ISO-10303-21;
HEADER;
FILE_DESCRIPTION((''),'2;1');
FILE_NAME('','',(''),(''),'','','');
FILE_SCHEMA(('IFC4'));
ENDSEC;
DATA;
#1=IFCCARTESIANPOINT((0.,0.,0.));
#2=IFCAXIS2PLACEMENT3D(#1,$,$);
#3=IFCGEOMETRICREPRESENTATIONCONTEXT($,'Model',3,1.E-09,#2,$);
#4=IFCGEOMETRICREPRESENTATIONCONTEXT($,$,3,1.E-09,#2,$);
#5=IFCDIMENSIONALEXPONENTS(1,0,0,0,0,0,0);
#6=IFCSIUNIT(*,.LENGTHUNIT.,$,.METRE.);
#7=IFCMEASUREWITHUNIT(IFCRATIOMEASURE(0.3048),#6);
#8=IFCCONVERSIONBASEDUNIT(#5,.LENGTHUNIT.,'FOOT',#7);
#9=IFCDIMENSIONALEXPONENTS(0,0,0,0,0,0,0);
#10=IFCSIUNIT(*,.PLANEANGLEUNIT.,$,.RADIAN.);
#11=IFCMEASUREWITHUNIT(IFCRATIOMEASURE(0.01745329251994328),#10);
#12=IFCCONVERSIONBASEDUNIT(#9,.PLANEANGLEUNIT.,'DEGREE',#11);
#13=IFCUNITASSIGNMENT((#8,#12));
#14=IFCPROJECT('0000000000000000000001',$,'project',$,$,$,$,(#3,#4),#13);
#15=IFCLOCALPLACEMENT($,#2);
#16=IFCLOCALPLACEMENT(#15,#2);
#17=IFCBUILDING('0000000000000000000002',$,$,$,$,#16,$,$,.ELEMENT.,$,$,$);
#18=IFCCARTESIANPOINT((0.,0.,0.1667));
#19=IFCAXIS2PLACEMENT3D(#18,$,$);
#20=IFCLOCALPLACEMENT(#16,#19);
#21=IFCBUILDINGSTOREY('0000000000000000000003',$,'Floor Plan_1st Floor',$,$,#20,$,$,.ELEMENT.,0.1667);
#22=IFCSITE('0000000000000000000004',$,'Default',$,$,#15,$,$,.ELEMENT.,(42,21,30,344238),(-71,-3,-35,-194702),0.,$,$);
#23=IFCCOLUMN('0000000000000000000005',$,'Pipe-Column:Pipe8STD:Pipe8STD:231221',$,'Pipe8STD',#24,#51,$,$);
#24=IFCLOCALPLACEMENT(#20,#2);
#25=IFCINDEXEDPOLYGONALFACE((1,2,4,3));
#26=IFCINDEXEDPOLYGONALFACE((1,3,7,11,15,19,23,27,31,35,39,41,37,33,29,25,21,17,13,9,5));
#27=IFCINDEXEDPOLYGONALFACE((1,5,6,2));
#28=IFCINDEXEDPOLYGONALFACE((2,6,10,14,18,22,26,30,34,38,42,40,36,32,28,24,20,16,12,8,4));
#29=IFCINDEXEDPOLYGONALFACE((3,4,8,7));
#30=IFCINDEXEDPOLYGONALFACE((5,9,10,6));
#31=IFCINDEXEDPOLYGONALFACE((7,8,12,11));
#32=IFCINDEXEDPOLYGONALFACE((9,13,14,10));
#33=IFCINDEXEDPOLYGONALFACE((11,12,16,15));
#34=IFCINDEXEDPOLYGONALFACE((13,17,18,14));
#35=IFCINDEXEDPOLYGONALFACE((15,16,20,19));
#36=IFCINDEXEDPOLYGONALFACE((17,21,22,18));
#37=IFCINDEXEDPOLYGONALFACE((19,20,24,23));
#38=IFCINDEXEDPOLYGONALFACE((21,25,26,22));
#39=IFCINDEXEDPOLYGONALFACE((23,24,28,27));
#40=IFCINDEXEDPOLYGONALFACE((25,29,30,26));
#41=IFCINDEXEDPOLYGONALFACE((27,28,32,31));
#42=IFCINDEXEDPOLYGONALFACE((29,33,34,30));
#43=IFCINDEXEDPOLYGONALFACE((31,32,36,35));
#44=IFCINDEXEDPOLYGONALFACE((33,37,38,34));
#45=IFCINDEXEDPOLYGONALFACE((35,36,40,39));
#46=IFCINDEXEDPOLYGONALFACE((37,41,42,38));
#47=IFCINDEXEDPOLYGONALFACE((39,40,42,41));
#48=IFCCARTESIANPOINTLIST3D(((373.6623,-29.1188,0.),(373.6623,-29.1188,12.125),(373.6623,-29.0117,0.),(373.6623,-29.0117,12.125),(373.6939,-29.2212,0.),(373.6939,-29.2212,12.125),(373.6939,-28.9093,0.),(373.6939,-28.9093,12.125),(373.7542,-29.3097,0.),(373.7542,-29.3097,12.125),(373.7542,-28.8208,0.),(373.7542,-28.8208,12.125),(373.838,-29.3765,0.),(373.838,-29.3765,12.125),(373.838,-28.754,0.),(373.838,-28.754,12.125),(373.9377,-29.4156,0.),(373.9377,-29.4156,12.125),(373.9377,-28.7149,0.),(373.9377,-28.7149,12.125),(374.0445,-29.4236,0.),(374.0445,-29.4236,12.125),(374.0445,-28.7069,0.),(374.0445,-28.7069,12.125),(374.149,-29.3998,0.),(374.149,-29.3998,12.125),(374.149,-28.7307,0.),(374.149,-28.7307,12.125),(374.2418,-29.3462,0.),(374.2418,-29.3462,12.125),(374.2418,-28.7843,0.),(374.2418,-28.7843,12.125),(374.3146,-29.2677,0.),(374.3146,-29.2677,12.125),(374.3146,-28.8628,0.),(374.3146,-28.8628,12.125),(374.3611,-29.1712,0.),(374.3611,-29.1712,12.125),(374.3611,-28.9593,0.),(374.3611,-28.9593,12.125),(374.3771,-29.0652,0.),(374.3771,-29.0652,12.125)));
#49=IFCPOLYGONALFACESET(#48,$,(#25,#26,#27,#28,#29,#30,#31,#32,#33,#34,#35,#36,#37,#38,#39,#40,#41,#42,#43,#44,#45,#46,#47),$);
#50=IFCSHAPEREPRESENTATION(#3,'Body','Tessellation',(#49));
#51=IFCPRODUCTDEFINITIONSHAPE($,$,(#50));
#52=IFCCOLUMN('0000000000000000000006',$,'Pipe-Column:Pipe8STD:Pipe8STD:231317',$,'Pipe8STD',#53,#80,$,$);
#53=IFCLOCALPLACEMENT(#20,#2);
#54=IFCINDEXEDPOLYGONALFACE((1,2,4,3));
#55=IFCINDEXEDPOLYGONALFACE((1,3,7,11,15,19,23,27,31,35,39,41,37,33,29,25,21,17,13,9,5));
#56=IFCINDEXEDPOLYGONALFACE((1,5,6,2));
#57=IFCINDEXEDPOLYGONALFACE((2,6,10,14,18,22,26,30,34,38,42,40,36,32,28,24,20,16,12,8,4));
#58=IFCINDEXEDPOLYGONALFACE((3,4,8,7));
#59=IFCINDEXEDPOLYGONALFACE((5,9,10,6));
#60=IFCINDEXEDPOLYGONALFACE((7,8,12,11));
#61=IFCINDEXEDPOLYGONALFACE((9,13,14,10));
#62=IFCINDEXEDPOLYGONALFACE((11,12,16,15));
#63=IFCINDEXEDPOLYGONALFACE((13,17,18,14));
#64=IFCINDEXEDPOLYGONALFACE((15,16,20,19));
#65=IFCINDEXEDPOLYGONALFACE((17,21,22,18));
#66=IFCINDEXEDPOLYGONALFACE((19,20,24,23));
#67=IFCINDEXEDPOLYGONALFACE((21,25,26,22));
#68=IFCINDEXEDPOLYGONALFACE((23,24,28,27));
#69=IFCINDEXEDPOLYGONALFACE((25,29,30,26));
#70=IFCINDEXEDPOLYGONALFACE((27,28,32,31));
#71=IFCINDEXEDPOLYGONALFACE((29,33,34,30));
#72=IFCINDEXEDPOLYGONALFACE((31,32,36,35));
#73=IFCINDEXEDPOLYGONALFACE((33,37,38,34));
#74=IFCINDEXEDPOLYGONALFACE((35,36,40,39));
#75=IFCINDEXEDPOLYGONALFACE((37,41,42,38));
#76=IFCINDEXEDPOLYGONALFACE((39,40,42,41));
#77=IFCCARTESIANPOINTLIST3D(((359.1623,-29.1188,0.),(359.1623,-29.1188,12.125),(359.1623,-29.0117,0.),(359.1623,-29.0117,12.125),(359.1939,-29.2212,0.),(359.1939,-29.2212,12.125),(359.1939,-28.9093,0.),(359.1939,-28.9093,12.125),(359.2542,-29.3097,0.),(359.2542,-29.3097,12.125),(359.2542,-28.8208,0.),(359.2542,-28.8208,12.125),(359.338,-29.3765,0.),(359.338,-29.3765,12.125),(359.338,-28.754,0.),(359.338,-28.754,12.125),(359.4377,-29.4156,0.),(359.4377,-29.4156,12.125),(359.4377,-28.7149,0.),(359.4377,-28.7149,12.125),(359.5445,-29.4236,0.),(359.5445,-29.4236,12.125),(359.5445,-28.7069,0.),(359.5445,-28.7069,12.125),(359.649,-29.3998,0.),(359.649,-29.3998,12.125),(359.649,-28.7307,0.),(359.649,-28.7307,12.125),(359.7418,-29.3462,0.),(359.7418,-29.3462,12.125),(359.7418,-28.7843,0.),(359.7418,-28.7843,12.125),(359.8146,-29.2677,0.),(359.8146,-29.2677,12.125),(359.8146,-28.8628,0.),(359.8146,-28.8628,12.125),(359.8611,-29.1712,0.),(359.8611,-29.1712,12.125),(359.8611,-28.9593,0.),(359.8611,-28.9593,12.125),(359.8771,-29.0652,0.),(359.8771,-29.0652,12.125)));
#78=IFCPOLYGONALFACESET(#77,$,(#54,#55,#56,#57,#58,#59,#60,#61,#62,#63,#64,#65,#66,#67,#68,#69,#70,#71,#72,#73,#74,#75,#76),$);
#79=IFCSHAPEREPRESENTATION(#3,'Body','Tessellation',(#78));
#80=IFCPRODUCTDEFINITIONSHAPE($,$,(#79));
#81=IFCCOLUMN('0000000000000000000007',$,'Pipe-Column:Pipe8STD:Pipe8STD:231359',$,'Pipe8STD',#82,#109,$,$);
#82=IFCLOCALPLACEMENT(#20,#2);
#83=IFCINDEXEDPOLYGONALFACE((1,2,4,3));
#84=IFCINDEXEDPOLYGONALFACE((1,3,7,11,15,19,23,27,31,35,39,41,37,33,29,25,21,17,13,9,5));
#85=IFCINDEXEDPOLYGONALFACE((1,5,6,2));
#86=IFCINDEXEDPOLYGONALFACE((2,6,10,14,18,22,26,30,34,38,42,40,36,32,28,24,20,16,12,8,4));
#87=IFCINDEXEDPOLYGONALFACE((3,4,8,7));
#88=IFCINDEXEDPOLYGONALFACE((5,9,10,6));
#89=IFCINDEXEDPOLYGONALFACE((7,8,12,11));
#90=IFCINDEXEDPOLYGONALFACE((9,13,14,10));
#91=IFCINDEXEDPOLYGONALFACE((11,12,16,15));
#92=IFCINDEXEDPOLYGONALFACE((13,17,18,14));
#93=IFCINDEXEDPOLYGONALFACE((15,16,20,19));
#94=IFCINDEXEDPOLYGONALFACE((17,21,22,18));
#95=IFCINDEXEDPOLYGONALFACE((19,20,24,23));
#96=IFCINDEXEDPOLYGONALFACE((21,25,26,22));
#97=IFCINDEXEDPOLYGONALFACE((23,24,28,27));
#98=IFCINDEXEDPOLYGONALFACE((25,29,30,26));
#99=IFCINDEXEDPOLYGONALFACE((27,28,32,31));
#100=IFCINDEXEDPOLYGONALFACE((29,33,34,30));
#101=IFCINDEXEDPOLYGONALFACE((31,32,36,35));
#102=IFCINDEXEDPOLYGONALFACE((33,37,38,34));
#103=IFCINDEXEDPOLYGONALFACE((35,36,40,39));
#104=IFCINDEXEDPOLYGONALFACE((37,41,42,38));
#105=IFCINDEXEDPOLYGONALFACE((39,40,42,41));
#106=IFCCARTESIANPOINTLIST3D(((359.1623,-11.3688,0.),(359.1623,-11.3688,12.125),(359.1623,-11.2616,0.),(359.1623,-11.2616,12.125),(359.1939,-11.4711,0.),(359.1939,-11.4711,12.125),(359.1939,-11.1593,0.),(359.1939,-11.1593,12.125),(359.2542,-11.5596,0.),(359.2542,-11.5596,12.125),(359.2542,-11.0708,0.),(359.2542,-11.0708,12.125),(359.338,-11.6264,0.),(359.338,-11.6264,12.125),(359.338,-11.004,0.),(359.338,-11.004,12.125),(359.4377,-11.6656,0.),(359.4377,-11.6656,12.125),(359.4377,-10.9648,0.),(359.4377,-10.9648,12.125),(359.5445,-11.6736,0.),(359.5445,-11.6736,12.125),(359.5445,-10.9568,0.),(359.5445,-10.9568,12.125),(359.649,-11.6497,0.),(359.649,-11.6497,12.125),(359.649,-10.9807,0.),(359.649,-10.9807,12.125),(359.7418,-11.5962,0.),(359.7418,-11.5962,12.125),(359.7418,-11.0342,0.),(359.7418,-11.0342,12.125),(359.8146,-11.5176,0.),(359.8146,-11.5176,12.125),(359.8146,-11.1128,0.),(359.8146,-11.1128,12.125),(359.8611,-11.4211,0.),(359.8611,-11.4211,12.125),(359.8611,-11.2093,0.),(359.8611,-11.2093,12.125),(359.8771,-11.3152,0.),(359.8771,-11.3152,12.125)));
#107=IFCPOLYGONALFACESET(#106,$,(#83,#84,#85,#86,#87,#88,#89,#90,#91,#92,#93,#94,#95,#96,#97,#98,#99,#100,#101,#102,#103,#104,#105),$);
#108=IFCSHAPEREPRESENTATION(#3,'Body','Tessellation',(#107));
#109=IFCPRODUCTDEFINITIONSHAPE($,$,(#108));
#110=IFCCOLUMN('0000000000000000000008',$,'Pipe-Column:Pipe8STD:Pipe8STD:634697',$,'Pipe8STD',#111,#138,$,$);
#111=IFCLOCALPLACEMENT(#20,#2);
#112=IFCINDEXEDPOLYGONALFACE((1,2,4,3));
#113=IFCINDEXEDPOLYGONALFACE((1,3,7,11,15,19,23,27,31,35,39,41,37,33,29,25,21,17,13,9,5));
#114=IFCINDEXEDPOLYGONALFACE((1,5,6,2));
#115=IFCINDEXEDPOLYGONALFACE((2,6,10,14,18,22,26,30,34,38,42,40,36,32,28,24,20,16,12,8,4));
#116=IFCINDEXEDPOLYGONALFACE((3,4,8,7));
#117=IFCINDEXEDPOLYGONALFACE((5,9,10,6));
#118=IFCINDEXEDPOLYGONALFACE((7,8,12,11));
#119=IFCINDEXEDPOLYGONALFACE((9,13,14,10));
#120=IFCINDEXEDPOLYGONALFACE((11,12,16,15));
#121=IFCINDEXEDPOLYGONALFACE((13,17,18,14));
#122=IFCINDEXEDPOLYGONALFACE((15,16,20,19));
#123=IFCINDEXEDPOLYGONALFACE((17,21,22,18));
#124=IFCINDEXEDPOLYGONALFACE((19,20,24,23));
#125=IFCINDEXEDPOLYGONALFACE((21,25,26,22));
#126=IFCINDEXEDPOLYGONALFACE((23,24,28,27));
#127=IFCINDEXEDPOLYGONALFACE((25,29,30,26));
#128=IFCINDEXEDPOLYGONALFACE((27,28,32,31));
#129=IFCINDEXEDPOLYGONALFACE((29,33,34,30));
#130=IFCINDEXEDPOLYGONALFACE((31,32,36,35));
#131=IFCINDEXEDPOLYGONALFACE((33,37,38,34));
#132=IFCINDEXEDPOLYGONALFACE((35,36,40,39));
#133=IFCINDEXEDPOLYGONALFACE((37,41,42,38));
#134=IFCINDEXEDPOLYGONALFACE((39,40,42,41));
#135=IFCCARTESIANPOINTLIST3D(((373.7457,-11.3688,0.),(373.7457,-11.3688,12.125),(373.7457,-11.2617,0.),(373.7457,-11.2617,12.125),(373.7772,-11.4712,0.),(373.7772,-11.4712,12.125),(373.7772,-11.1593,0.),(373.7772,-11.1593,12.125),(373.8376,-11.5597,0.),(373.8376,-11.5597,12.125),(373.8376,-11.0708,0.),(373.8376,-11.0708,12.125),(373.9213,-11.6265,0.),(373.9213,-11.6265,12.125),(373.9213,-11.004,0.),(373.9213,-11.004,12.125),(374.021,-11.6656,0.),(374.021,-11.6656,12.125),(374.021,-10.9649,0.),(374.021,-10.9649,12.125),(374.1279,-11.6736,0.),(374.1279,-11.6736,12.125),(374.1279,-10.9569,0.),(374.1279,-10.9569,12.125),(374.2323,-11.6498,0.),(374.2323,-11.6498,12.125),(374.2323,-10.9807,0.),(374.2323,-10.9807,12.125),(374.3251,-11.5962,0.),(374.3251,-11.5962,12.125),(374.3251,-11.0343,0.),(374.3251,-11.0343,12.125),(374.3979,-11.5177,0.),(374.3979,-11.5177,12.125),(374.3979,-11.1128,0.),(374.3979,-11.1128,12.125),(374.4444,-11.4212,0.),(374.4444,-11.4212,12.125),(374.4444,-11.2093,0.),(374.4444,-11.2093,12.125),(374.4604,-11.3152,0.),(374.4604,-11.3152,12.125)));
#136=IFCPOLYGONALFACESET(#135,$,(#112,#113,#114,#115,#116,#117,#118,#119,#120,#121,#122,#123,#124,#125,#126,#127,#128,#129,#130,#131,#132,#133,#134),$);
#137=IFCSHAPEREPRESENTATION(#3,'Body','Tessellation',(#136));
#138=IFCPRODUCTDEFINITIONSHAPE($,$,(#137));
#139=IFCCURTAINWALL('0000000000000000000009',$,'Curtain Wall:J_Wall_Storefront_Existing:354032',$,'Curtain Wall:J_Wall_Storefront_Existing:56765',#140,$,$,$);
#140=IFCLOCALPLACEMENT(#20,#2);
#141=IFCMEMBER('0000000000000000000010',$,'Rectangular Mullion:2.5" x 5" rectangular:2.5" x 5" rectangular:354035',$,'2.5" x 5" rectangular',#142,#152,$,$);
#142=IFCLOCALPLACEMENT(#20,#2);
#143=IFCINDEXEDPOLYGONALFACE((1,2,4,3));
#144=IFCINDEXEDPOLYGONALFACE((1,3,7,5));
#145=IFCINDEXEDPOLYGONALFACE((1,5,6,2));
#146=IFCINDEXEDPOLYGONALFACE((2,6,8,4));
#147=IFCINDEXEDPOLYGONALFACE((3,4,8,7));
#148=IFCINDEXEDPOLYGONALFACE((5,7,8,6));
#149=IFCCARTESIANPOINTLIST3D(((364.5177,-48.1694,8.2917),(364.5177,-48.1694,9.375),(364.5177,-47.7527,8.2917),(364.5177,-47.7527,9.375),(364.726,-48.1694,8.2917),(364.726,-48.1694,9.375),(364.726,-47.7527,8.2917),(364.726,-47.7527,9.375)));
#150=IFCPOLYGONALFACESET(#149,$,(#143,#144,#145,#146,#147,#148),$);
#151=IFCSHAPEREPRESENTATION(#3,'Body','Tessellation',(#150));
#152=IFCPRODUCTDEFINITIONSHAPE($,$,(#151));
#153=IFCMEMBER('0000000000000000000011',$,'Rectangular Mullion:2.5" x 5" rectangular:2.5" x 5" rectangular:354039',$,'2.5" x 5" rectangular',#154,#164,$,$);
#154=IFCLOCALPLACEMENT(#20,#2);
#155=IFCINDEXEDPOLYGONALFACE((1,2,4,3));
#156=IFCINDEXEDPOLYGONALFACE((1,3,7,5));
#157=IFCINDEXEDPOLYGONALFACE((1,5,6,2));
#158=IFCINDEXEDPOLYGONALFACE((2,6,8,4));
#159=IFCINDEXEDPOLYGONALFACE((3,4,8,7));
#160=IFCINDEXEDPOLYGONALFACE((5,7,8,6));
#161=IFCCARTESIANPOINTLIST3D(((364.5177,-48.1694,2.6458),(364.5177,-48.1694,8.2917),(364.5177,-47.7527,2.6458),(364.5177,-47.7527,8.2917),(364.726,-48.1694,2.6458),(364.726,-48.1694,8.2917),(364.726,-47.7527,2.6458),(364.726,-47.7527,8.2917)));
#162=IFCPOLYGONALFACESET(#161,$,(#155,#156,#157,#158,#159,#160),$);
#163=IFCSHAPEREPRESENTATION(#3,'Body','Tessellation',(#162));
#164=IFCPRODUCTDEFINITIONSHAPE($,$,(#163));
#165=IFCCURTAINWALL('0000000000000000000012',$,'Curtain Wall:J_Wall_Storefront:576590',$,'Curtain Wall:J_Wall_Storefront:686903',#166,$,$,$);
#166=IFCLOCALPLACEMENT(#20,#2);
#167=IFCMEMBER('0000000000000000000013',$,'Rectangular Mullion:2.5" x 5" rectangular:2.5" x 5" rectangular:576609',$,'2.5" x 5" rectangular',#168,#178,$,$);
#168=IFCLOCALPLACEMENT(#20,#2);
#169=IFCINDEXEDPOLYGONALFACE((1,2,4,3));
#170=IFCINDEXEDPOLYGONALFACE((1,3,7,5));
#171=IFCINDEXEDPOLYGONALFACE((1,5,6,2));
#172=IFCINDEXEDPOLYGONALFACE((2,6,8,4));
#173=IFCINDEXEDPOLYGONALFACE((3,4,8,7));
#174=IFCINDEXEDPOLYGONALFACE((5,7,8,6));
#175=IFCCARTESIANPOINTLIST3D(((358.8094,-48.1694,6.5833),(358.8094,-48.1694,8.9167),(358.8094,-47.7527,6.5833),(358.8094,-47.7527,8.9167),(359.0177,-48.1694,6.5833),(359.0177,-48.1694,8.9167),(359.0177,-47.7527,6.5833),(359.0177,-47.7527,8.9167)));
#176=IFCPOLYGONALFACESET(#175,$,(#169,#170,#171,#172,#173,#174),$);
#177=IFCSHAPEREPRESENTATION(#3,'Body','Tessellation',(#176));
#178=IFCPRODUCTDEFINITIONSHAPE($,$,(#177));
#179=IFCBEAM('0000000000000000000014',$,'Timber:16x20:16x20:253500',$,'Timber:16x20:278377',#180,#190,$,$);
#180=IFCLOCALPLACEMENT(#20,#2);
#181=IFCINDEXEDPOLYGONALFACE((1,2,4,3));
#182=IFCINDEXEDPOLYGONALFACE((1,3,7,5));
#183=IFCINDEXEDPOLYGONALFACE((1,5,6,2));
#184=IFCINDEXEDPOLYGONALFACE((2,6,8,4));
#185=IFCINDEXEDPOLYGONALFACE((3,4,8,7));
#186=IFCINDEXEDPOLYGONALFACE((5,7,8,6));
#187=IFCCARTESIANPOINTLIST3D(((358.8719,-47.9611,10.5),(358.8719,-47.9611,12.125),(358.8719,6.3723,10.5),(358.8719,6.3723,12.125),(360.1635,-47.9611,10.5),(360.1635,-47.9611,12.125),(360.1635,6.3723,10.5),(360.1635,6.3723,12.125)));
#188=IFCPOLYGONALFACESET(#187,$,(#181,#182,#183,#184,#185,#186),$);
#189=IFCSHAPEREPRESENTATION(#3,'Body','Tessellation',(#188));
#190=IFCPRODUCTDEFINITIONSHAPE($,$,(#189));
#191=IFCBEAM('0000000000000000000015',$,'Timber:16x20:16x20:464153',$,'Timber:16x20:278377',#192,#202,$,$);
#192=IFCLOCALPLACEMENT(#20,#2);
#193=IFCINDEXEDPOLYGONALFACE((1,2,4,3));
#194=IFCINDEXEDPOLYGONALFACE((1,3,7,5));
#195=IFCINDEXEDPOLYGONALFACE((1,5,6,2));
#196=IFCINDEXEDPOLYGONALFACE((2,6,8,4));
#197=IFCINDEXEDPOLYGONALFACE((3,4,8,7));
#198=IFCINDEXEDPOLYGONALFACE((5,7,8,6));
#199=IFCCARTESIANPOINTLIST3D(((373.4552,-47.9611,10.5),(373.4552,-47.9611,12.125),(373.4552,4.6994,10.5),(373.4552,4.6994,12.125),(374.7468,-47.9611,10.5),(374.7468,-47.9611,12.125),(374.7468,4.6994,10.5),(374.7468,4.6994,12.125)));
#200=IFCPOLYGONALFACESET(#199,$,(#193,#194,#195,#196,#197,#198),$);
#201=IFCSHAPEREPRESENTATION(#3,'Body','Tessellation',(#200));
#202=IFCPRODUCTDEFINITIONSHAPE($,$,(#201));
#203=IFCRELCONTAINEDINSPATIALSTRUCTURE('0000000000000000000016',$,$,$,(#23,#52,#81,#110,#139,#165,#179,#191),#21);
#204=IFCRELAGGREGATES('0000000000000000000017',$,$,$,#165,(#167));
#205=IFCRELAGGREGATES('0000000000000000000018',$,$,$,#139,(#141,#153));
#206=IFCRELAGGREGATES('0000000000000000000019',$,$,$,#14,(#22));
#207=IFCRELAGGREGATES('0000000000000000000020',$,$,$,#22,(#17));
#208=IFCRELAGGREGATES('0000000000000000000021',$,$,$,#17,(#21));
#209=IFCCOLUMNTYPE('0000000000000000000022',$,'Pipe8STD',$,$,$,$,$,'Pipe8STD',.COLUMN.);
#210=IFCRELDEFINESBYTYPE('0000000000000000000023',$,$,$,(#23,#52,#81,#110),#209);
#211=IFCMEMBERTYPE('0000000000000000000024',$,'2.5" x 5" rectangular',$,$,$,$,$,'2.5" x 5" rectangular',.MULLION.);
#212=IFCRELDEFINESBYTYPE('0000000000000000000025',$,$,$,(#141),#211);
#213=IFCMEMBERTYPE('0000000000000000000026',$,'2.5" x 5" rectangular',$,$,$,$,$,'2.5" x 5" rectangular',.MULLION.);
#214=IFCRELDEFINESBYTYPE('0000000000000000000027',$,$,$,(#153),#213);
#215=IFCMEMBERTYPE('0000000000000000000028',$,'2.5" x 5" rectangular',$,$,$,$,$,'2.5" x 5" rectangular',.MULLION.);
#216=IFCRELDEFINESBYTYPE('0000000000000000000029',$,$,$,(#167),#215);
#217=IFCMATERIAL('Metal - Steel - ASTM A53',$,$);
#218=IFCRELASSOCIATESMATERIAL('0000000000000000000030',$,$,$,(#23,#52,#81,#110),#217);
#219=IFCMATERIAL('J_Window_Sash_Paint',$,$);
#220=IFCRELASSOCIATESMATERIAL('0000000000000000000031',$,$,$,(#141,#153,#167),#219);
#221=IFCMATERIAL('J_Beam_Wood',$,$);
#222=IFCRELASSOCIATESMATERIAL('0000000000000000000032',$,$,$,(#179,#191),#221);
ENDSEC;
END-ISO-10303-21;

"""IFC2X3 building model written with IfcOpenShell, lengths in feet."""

from ifc_helpers import new_model, entity, si_unit, converted_unit, frame, frame_2d, origin, origin_2d_with_axis, place, context, project, spatial, rectangle, circle, extrude, source, transform, mapped, material, type_object, type_shapes, element, aggregate, save


model = new_model("IFC2X3")

# Units and contexts
model_context = context("Model", 3, precision=1e-09, world=origin())
context_of_model = context(None, 3, precision=1e-09, world=origin())
ifc_project = project(units=[converted_unit("LENGTHUNIT", "FOOT", entity("IfcRatioMeasure", 0.3048), si_unit("LENGTHUNIT", "METRE"), dimensions=[1, 0, 0, 0, 0, 0, 0]), converted_unit("PLANEANGLEUNIT", "DEGREE", entity("IfcRatioMeasure", 0.01745329251994328), si_unit("PLANEANGLEUNIT", "RADIAN"), dimensions=[0, 0, 0, 0, 0, 0, 0])], contexts=[model_context, context_of_model])

# Site, building, storey
site_placement = place(None, origin())
site = spatial("IfcSite", under=ifc_project, at=site_placement, Name="Default", CompositionType="ELEMENT", RefLatitude=(42, 21, 30, 344238), RefLongitude=(-71, -3, -35, -194702), RefElevation=0.0)
building_placement = place(site_placement, origin())
building = spatial("IfcBuilding", under=site, at=building_placement, CompositionType="ELEMENT")
storey_placement = place(building_placement, frame((0.0, 0.0, 0.1667)))
storey = spatial("IfcBuildingStorey", under=building, at=storey_placement, Name="Floor Plan_1st Floor", CompositionType="ELEMENT", Elevation=0.1667)

# Columns
ifc_material_1 = material(Name="Metal - Steel - ASTM A53")
column_type = type_object("IfcColumnType", Name="Pipe8STD", ElementType="Pipe8STD", PredefinedType="COLUMN")
shared_shape_1 = source(origin(), model_context, "Body", "SweptSolid", [
    extrude(circle(Radius=0.3594, at=origin_2d_with_axis()), origin(), (0.0, 0.0, 1.0), 12.125),
])
type_shapes(column_type, [shared_shape_1])
for number, where, name in (
    (1, (374.0177, -29.0652, 0.0), "Pipe-Column:Pipe8STD:Pipe8STD:231221"),
    (2, (359.5177, -29.0652, 0.0), "Pipe-Column:Pipe8STD:Pipe8STD:231317"),
    (3, (359.5177, -11.3152, 0.0), "Pipe-Column:Pipe8STD:Pipe8STD:231359"),
    (4, (374.101, -11.3152, 0.0), "Pipe-Column:Pipe8STD:Pipe8STD:634697"),
):
    element("IfcColumn", number, at=place(storey_placement, frame(where)), inside=storey, type_object=column_type, material=ifc_material_1, Name=name, ObjectType="Pipe8STD", context=model_context, shape_type="MappedRepresentation", body=[
        mapped(shared_shape_1, transform((0.0, 0.0, 0.0), scale=1.0)),
    ])

# Curtain wall, members
curtain_wall_1_placement = place(storey_placement, origin())
curtain_wall_1 = element("IfcCurtainWall", 5, at=curtain_wall_1_placement, inside=storey, Name="Curtain Wall:J_Wall_Storefront_Existing:354032", ObjectType="Curtain Wall:J_Wall_Storefront_Existing:56765")
ifc_material_2 = material(Name="J_Window_Sash_Paint")
member_type_1 = type_object("IfcMemberType", Name="2.5\" x 5\" rectangular", ElementType="2.5\" x 5\" rectangular", PredefinedType="MULLION")
shared_shape_2 = source(origin(), model_context, "Body", "SweptSolid", [
    extrude(rectangle(XDim=0.2083, YDim=0.4167, at=origin_2d_with_axis()), frame((-0.1042, 0.0, -1.0833), z_axis=(0.0, 0.0, 1.0), x_axis=(-1.0, 0.0, 0.0)), (0.0, 0.0, 1.0), 1.0833),
])
type_shapes(member_type_1, [shared_shape_2])
member_1_placement = place(storey_placement, frame((364.5177, -47.9611, 9.375), z_axis=(0.0, 0.0, 1.0), x_axis=(-1.0, 0.0, 0.0)))
member_1 = element("IfcMember", 6, at=member_1_placement, type_object=member_type_1, material=ifc_material_2, Name="Rectangular Mullion:2.5\" x 5\" rectangular:2.5\" x 5\" rectangular:354035", ObjectType="2.5\" x 5\" rectangular", context=model_context, shape_type="MappedRepresentation", body=[
    mapped(shared_shape_2, transform((0.0, 0.0, 0.0), scale=1.0)),
])
member_type_2 = type_object("IfcMemberType", Name="2.5\" x 5\" rectangular", ElementType="2.5\" x 5\" rectangular", PredefinedType="MULLION")
shared_shape_3 = source(origin(), model_context, "Body", "SweptSolid", [
    extrude(rectangle(XDim=0.2083, YDim=0.4167, at=origin_2d_with_axis()), frame((-0.1042, 0.0, -5.6458), z_axis=(0.0, 0.0, 1.0), x_axis=(-1.0, 0.0, 0.0)), (0.0, 0.0, 1.0), 5.6458),
])
type_shapes(member_type_2, [shared_shape_3])
member_2_placement = place(storey_placement, frame((364.5177, -47.9611, 8.2917), z_axis=(0.0, 0.0, 1.0), x_axis=(-1.0, 0.0, 0.0)))
member_2 = element("IfcMember", 7, at=member_2_placement, type_object=member_type_2, material=ifc_material_2, Name="Rectangular Mullion:2.5\" x 5\" rectangular:2.5\" x 5\" rectangular:354039", ObjectType="2.5\" x 5\" rectangular", context=model_context, shape_type="MappedRepresentation", body=[
    mapped(shared_shape_3, transform((0.0, 0.0, 0.0), scale=1.0)),
])

# Curtain wall, member
curtain_wall_2_placement = place(storey_placement, origin())
curtain_wall_2 = element("IfcCurtainWall", 8, at=curtain_wall_2_placement, inside=storey, Name="Curtain Wall:J_Wall_Storefront:576590", ObjectType="Curtain Wall:J_Wall_Storefront:686903")
member_type_3 = type_object("IfcMemberType", Name="2.5\" x 5\" rectangular", ElementType="2.5\" x 5\" rectangular", PredefinedType="MULLION")
shared_shape_4 = source(origin(), model_context, "Body", "SweptSolid", [
    extrude(rectangle(XDim=0.2083, YDim=0.4167, at=origin_2d_with_axis()), frame((-0.1042, 0.0, -2.3333), z_axis=(0.0, 0.0, 1.0), x_axis=(-1.0, 0.0, 0.0)), (0.0, 0.0, 1.0), 2.3333),
])
type_shapes(member_type_3, [shared_shape_4])
member_3_placement = place(storey_placement, frame((359.0177, -47.9611, 6.5833), z_axis=(0.0, 0.0, -1.0), x_axis=(1.0, 0.0, 0.0)))
member_3 = element("IfcMember", 9, at=member_3_placement, type_object=member_type_3, material=ifc_material_2, Name="Rectangular Mullion:2.5\" x 5\" rectangular:2.5\" x 5\" rectangular:576609", ObjectType="2.5\" x 5\" rectangular", context=model_context, shape_type="MappedRepresentation", body=[
    mapped(shared_shape_4, transform((0.0, 0.0, 0.0), scale=1.0)),
])
aggregate(curtain_wall_2, [member_3])

# Beams
ifc_material_3 = material(Name="J_Beam_Wood")
beam_1_placement = place(storey_placement, frame((359.5177, -29.0652, 12.125), z_axis=(0.0, 0.0, 1.0), x_axis=(-1.0, 0.0, 0.0)))
element("IfcBeam", 10, at=beam_1_placement, inside=storey, material=ifc_material_3, Name="Timber:16x20:16x20:253500", ObjectType="Timber:16x20:278377", context=model_context, shape_type="SweptSolid", body=[
    extrude(rectangle(XDim=1.625, YDim=54.3333, at=frame_2d((0.0, 0.0), x_axis=(0.0, 1.0))), frame((0.6458, -8.2708, -0.8125), z_axis=(-1.0, 0.0, 0.0), x_axis=(0.0, -1.0, 0.0)), (0.0, 0.0, 1.0), 1.2917),
])
beam_2_placement = place(storey_placement, frame((374.101, -29.0652, 12.125), z_axis=(0.0, 0.0, 1.0), x_axis=(-1.0, 0.0, 0.0)))
element("IfcBeam", 11, at=beam_2_placement, inside=storey, material=ifc_material_3, Name="Timber:16x20:16x20:464153", ObjectType="Timber:16x20:278377", context=model_context, shape_type="SweptSolid", body=[
    extrude(rectangle(XDim=1.625, YDim=52.6605, at=frame_2d((0.0, 0.0), x_axis=(0.0, 1.0))), frame((0.6458, -7.4344, -0.8125), z_axis=(-1.0, 0.0, 0.0), x_axis=(0.0, -1.0, 0.0)), (0.0, 0.0, 1.0), 1.2917),
])

aggregate(curtain_wall_1, [member_1, member_2])

save(model, "model.ifc")
